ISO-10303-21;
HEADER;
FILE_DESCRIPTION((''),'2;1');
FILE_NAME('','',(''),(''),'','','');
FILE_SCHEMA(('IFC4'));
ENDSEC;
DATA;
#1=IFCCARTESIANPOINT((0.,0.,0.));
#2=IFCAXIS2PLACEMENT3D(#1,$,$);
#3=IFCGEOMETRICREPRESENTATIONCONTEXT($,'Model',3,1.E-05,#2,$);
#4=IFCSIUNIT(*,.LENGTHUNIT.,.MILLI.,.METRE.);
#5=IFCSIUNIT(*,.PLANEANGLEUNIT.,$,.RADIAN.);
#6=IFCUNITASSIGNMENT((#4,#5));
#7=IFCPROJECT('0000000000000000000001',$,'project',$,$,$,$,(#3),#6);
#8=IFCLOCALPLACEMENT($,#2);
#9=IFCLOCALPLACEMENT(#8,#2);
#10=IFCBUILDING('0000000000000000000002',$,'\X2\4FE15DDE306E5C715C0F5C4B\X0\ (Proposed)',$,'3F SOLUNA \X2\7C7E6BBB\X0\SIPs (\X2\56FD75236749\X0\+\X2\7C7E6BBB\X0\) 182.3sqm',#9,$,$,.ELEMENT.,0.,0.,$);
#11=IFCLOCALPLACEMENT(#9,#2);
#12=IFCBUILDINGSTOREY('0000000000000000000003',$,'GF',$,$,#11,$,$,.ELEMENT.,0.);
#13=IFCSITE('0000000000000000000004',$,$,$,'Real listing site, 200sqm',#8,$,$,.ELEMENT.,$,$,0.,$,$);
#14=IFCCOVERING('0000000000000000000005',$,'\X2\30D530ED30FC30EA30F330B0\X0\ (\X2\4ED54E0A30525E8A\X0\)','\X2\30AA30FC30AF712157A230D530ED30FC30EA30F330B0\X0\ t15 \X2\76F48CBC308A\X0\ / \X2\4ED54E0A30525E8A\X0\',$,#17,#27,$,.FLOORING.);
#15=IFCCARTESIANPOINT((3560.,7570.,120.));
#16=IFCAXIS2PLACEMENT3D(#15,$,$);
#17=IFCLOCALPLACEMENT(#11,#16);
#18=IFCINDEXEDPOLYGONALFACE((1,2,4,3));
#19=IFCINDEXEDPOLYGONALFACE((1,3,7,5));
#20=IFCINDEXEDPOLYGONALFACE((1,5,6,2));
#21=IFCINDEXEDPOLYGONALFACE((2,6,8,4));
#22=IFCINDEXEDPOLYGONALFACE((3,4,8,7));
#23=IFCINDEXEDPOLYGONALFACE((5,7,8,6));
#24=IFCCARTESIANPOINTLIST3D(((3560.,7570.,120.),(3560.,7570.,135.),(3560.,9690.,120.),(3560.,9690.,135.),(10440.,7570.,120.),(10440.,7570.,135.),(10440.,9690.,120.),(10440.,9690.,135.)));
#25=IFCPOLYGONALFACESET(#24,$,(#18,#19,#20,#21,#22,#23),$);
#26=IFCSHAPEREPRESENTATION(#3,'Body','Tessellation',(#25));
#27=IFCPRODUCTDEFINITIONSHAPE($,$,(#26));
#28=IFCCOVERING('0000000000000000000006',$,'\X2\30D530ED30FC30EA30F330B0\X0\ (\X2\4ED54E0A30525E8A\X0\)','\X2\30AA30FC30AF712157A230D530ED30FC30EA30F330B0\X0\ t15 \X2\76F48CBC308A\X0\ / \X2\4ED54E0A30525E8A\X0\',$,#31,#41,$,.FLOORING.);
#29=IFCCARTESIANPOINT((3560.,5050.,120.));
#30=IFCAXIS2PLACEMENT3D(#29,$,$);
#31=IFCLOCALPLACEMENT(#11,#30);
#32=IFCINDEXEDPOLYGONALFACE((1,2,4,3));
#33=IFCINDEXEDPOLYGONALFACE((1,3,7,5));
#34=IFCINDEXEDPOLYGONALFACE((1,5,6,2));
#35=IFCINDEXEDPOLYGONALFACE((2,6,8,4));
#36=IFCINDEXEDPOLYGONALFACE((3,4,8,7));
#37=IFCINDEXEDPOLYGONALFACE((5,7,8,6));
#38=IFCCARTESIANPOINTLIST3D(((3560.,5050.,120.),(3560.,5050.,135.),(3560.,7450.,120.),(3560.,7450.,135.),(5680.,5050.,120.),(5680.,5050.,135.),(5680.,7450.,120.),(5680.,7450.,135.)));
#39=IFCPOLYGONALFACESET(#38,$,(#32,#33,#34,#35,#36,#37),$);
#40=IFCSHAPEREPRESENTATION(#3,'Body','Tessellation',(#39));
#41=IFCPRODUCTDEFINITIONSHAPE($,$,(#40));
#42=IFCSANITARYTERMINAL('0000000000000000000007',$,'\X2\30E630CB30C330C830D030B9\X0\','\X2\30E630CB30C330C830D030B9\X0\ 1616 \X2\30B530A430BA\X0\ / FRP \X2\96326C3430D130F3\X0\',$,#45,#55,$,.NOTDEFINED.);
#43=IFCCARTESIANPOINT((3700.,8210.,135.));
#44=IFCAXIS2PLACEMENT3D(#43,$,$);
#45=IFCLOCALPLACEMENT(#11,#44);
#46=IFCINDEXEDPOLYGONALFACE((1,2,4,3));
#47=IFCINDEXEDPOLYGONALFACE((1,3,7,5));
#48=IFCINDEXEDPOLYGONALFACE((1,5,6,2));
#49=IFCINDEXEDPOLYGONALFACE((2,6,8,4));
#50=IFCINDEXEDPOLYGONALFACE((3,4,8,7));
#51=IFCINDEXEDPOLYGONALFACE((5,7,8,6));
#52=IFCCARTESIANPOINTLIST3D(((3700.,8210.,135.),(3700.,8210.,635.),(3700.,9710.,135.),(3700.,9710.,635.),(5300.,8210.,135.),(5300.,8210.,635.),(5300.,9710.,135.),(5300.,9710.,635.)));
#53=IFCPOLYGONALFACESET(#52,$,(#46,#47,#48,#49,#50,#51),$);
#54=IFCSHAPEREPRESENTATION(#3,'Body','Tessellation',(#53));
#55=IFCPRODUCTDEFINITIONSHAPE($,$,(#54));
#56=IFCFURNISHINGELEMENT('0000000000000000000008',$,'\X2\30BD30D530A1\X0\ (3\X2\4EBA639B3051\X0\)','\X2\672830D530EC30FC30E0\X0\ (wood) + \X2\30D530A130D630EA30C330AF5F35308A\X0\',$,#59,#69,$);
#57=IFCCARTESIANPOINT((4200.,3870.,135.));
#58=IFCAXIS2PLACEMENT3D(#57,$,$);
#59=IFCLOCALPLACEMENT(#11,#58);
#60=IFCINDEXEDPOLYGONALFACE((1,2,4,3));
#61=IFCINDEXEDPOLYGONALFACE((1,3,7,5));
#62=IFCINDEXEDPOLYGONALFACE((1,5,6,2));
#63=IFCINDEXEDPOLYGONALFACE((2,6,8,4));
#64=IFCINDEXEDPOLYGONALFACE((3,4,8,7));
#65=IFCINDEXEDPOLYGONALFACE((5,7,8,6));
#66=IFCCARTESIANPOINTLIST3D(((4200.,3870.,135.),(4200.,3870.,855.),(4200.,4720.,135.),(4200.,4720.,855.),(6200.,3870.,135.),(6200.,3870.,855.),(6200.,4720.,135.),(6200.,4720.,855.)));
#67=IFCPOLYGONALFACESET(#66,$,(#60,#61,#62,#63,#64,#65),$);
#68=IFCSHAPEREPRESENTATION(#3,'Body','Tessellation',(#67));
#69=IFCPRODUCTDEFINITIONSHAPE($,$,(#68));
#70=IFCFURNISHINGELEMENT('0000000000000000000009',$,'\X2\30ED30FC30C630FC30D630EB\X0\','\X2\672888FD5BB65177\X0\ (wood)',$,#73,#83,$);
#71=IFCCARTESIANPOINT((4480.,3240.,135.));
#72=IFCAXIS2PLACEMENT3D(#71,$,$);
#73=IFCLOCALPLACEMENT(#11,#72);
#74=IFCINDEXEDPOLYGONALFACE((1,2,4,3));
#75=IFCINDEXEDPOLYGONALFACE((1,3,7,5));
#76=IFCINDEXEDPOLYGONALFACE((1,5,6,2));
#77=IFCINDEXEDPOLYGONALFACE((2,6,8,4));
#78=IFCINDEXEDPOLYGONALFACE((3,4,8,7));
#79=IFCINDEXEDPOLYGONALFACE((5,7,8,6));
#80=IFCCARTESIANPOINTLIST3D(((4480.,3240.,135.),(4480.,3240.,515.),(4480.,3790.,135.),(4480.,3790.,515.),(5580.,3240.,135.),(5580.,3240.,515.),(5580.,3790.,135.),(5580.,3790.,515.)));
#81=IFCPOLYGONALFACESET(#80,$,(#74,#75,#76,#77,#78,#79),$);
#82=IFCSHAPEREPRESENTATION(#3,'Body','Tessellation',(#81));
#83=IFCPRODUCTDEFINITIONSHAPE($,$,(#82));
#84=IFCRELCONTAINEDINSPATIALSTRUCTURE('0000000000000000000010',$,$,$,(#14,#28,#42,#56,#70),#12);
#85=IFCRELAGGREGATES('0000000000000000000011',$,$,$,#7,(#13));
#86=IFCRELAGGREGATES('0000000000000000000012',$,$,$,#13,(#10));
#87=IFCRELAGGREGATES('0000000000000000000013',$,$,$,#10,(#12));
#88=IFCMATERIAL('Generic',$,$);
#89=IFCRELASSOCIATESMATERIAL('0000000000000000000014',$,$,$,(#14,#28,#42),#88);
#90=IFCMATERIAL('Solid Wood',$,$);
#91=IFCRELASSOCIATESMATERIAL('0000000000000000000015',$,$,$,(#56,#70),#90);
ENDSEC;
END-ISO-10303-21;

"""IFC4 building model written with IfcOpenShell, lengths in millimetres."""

from ifc_helpers import new_model, si_unit, frame, frame_2d, origin, place, context, project, spatial, rectangle, extrude, material, element, save


model = new_model("IFC4")

# Units and contexts
model_context = context("Model", 3, precision=1e-05, world=origin())
ifc_project = project(units=[si_unit("LENGTHUNIT", "METRE", prefix="MILLI"), si_unit("PLANEANGLEUNIT", "RADIAN")], contexts=[model_context])

# Site, building, storey
site_placement = place(None, origin())
site = spatial("IfcSite", under=ifc_project, at=site_placement, ObjectType="Real listing site, 200sqm", CompositionType="ELEMENT", RefElevation=0.0)
building_placement = place(site_placement, origin())
building = spatial("IfcBuilding", under=site, at=building_placement, Name="信州の山小屋 (Proposed)", ObjectType="3F SOLUNA 籾殻SIPs (国産杉+籾殻) 182.3sqm", CompositionType="ELEMENT", ElevationOfRefHeight=0.0, ElevationOfTerrain=0.0)
storey_placement = place(building_placement, origin())
storey = spatial("IfcBuildingStorey", under=building, at=storey_placement, Name="GF", CompositionType="ELEMENT", Elevation=0.0)

# Shared definitions
ifc_material_1 = material(Name="Solid Wood")

# Coverings
ifc_material_2 = material(Name="Generic")
covering_1_placement = place(storey_placement, frame((3560.0, 7570.0, 120.0)))
element("IfcCovering", 1, at=covering_1_placement, inside=storey, material=ifc_material_2, Name="フローリング (仕上げ床)", Description="オーク無垢フローリング t15 直貼り / 仕上げ床", PredefinedType="FLOORING", context=model_context, shape_type="SweptSolid", body=[
    extrude(rectangle(XDim=6880.0, YDim=2120.0, at=frame_2d((3440.0, 1060.0))), frame((3560.0, 7570.0, 120.0)), (0.0, 0.0, 1.0), 15.0),
])
covering_2_placement = place(storey_placement, frame((3560.0, 5050.0, 120.0)))
element("IfcCovering", 2, at=covering_2_placement, inside=storey, material=ifc_material_2, Name="フローリング (仕上げ床)", Description="オーク無垢フローリング t15 直貼り / 仕上げ床", PredefinedType="FLOORING", context=model_context, shape_type="SweptSolid", body=[
    extrude(rectangle(XDim=2120.0, YDim=2400.0, at=frame_2d((1060.0, 1200.0))), frame((3560.0, 5050.0, 120.0)), (0.0, 0.0, 1.0), 15.0),
])

# Sanitary terminal
sanitary_terminal_placement = place(storey_placement, frame((3700.0, 8210.0, 135.0)))
element("IfcSanitaryTerminal", 3, at=sanitary_terminal_placement, inside=storey, material=ifc_material_2, Name="ユニットバス", Description="ユニットバス 1616 サイズ / FRP 防水パン", PredefinedType="NOTDEFINED", context=model_context, shape_type="SweptSolid", body=[
    extrude(rectangle(XDim=1600.0, YDim=1500.0, at=frame_2d((800.0, 750.0))), frame((3700.0, 8210.0, 135.0)), (0.0, 0.0, 1.0), 500.0),
])

# Furnishing elements
furnishing_1_placement = place(storey_placement, frame((4200.0, 3870.0, 135.0)))
element("IfcFurnishingElement", 4, at=furnishing_1_placement, inside=storey, material=ifc_material_1, Name="ソファ (3人掛け)", Description="木フレーム (wood) + ファブリック張り", context=model_context, shape_type="SweptSolid", body=[
    extrude(rectangle(XDim=2000.0, YDim=850.0, at=frame_2d((1000.0, 425.0))), frame((4200.0, 3870.0, 135.0)), (0.0, 0.0, 1.0), 720.0),
])
furnishing_2_placement = place(storey_placement, frame((4480.0, 3240.0, 135.0)))
element("IfcFurnishingElement", 5, at=furnishing_2_placement, inside=storey, material=ifc_material_1, Name="ローテーブル", Description="木製家具 (wood)", context=model_context, shape_type="SweptSolid", body=[
    extrude(rectangle(XDim=1100.0, YDim=550.0, at=frame_2d((550.0, 275.0))), frame((4480.0, 3240.0, 135.0)), (0.0, 0.0, 1.0), 380.0),
])

save(model, "model.ifc")
